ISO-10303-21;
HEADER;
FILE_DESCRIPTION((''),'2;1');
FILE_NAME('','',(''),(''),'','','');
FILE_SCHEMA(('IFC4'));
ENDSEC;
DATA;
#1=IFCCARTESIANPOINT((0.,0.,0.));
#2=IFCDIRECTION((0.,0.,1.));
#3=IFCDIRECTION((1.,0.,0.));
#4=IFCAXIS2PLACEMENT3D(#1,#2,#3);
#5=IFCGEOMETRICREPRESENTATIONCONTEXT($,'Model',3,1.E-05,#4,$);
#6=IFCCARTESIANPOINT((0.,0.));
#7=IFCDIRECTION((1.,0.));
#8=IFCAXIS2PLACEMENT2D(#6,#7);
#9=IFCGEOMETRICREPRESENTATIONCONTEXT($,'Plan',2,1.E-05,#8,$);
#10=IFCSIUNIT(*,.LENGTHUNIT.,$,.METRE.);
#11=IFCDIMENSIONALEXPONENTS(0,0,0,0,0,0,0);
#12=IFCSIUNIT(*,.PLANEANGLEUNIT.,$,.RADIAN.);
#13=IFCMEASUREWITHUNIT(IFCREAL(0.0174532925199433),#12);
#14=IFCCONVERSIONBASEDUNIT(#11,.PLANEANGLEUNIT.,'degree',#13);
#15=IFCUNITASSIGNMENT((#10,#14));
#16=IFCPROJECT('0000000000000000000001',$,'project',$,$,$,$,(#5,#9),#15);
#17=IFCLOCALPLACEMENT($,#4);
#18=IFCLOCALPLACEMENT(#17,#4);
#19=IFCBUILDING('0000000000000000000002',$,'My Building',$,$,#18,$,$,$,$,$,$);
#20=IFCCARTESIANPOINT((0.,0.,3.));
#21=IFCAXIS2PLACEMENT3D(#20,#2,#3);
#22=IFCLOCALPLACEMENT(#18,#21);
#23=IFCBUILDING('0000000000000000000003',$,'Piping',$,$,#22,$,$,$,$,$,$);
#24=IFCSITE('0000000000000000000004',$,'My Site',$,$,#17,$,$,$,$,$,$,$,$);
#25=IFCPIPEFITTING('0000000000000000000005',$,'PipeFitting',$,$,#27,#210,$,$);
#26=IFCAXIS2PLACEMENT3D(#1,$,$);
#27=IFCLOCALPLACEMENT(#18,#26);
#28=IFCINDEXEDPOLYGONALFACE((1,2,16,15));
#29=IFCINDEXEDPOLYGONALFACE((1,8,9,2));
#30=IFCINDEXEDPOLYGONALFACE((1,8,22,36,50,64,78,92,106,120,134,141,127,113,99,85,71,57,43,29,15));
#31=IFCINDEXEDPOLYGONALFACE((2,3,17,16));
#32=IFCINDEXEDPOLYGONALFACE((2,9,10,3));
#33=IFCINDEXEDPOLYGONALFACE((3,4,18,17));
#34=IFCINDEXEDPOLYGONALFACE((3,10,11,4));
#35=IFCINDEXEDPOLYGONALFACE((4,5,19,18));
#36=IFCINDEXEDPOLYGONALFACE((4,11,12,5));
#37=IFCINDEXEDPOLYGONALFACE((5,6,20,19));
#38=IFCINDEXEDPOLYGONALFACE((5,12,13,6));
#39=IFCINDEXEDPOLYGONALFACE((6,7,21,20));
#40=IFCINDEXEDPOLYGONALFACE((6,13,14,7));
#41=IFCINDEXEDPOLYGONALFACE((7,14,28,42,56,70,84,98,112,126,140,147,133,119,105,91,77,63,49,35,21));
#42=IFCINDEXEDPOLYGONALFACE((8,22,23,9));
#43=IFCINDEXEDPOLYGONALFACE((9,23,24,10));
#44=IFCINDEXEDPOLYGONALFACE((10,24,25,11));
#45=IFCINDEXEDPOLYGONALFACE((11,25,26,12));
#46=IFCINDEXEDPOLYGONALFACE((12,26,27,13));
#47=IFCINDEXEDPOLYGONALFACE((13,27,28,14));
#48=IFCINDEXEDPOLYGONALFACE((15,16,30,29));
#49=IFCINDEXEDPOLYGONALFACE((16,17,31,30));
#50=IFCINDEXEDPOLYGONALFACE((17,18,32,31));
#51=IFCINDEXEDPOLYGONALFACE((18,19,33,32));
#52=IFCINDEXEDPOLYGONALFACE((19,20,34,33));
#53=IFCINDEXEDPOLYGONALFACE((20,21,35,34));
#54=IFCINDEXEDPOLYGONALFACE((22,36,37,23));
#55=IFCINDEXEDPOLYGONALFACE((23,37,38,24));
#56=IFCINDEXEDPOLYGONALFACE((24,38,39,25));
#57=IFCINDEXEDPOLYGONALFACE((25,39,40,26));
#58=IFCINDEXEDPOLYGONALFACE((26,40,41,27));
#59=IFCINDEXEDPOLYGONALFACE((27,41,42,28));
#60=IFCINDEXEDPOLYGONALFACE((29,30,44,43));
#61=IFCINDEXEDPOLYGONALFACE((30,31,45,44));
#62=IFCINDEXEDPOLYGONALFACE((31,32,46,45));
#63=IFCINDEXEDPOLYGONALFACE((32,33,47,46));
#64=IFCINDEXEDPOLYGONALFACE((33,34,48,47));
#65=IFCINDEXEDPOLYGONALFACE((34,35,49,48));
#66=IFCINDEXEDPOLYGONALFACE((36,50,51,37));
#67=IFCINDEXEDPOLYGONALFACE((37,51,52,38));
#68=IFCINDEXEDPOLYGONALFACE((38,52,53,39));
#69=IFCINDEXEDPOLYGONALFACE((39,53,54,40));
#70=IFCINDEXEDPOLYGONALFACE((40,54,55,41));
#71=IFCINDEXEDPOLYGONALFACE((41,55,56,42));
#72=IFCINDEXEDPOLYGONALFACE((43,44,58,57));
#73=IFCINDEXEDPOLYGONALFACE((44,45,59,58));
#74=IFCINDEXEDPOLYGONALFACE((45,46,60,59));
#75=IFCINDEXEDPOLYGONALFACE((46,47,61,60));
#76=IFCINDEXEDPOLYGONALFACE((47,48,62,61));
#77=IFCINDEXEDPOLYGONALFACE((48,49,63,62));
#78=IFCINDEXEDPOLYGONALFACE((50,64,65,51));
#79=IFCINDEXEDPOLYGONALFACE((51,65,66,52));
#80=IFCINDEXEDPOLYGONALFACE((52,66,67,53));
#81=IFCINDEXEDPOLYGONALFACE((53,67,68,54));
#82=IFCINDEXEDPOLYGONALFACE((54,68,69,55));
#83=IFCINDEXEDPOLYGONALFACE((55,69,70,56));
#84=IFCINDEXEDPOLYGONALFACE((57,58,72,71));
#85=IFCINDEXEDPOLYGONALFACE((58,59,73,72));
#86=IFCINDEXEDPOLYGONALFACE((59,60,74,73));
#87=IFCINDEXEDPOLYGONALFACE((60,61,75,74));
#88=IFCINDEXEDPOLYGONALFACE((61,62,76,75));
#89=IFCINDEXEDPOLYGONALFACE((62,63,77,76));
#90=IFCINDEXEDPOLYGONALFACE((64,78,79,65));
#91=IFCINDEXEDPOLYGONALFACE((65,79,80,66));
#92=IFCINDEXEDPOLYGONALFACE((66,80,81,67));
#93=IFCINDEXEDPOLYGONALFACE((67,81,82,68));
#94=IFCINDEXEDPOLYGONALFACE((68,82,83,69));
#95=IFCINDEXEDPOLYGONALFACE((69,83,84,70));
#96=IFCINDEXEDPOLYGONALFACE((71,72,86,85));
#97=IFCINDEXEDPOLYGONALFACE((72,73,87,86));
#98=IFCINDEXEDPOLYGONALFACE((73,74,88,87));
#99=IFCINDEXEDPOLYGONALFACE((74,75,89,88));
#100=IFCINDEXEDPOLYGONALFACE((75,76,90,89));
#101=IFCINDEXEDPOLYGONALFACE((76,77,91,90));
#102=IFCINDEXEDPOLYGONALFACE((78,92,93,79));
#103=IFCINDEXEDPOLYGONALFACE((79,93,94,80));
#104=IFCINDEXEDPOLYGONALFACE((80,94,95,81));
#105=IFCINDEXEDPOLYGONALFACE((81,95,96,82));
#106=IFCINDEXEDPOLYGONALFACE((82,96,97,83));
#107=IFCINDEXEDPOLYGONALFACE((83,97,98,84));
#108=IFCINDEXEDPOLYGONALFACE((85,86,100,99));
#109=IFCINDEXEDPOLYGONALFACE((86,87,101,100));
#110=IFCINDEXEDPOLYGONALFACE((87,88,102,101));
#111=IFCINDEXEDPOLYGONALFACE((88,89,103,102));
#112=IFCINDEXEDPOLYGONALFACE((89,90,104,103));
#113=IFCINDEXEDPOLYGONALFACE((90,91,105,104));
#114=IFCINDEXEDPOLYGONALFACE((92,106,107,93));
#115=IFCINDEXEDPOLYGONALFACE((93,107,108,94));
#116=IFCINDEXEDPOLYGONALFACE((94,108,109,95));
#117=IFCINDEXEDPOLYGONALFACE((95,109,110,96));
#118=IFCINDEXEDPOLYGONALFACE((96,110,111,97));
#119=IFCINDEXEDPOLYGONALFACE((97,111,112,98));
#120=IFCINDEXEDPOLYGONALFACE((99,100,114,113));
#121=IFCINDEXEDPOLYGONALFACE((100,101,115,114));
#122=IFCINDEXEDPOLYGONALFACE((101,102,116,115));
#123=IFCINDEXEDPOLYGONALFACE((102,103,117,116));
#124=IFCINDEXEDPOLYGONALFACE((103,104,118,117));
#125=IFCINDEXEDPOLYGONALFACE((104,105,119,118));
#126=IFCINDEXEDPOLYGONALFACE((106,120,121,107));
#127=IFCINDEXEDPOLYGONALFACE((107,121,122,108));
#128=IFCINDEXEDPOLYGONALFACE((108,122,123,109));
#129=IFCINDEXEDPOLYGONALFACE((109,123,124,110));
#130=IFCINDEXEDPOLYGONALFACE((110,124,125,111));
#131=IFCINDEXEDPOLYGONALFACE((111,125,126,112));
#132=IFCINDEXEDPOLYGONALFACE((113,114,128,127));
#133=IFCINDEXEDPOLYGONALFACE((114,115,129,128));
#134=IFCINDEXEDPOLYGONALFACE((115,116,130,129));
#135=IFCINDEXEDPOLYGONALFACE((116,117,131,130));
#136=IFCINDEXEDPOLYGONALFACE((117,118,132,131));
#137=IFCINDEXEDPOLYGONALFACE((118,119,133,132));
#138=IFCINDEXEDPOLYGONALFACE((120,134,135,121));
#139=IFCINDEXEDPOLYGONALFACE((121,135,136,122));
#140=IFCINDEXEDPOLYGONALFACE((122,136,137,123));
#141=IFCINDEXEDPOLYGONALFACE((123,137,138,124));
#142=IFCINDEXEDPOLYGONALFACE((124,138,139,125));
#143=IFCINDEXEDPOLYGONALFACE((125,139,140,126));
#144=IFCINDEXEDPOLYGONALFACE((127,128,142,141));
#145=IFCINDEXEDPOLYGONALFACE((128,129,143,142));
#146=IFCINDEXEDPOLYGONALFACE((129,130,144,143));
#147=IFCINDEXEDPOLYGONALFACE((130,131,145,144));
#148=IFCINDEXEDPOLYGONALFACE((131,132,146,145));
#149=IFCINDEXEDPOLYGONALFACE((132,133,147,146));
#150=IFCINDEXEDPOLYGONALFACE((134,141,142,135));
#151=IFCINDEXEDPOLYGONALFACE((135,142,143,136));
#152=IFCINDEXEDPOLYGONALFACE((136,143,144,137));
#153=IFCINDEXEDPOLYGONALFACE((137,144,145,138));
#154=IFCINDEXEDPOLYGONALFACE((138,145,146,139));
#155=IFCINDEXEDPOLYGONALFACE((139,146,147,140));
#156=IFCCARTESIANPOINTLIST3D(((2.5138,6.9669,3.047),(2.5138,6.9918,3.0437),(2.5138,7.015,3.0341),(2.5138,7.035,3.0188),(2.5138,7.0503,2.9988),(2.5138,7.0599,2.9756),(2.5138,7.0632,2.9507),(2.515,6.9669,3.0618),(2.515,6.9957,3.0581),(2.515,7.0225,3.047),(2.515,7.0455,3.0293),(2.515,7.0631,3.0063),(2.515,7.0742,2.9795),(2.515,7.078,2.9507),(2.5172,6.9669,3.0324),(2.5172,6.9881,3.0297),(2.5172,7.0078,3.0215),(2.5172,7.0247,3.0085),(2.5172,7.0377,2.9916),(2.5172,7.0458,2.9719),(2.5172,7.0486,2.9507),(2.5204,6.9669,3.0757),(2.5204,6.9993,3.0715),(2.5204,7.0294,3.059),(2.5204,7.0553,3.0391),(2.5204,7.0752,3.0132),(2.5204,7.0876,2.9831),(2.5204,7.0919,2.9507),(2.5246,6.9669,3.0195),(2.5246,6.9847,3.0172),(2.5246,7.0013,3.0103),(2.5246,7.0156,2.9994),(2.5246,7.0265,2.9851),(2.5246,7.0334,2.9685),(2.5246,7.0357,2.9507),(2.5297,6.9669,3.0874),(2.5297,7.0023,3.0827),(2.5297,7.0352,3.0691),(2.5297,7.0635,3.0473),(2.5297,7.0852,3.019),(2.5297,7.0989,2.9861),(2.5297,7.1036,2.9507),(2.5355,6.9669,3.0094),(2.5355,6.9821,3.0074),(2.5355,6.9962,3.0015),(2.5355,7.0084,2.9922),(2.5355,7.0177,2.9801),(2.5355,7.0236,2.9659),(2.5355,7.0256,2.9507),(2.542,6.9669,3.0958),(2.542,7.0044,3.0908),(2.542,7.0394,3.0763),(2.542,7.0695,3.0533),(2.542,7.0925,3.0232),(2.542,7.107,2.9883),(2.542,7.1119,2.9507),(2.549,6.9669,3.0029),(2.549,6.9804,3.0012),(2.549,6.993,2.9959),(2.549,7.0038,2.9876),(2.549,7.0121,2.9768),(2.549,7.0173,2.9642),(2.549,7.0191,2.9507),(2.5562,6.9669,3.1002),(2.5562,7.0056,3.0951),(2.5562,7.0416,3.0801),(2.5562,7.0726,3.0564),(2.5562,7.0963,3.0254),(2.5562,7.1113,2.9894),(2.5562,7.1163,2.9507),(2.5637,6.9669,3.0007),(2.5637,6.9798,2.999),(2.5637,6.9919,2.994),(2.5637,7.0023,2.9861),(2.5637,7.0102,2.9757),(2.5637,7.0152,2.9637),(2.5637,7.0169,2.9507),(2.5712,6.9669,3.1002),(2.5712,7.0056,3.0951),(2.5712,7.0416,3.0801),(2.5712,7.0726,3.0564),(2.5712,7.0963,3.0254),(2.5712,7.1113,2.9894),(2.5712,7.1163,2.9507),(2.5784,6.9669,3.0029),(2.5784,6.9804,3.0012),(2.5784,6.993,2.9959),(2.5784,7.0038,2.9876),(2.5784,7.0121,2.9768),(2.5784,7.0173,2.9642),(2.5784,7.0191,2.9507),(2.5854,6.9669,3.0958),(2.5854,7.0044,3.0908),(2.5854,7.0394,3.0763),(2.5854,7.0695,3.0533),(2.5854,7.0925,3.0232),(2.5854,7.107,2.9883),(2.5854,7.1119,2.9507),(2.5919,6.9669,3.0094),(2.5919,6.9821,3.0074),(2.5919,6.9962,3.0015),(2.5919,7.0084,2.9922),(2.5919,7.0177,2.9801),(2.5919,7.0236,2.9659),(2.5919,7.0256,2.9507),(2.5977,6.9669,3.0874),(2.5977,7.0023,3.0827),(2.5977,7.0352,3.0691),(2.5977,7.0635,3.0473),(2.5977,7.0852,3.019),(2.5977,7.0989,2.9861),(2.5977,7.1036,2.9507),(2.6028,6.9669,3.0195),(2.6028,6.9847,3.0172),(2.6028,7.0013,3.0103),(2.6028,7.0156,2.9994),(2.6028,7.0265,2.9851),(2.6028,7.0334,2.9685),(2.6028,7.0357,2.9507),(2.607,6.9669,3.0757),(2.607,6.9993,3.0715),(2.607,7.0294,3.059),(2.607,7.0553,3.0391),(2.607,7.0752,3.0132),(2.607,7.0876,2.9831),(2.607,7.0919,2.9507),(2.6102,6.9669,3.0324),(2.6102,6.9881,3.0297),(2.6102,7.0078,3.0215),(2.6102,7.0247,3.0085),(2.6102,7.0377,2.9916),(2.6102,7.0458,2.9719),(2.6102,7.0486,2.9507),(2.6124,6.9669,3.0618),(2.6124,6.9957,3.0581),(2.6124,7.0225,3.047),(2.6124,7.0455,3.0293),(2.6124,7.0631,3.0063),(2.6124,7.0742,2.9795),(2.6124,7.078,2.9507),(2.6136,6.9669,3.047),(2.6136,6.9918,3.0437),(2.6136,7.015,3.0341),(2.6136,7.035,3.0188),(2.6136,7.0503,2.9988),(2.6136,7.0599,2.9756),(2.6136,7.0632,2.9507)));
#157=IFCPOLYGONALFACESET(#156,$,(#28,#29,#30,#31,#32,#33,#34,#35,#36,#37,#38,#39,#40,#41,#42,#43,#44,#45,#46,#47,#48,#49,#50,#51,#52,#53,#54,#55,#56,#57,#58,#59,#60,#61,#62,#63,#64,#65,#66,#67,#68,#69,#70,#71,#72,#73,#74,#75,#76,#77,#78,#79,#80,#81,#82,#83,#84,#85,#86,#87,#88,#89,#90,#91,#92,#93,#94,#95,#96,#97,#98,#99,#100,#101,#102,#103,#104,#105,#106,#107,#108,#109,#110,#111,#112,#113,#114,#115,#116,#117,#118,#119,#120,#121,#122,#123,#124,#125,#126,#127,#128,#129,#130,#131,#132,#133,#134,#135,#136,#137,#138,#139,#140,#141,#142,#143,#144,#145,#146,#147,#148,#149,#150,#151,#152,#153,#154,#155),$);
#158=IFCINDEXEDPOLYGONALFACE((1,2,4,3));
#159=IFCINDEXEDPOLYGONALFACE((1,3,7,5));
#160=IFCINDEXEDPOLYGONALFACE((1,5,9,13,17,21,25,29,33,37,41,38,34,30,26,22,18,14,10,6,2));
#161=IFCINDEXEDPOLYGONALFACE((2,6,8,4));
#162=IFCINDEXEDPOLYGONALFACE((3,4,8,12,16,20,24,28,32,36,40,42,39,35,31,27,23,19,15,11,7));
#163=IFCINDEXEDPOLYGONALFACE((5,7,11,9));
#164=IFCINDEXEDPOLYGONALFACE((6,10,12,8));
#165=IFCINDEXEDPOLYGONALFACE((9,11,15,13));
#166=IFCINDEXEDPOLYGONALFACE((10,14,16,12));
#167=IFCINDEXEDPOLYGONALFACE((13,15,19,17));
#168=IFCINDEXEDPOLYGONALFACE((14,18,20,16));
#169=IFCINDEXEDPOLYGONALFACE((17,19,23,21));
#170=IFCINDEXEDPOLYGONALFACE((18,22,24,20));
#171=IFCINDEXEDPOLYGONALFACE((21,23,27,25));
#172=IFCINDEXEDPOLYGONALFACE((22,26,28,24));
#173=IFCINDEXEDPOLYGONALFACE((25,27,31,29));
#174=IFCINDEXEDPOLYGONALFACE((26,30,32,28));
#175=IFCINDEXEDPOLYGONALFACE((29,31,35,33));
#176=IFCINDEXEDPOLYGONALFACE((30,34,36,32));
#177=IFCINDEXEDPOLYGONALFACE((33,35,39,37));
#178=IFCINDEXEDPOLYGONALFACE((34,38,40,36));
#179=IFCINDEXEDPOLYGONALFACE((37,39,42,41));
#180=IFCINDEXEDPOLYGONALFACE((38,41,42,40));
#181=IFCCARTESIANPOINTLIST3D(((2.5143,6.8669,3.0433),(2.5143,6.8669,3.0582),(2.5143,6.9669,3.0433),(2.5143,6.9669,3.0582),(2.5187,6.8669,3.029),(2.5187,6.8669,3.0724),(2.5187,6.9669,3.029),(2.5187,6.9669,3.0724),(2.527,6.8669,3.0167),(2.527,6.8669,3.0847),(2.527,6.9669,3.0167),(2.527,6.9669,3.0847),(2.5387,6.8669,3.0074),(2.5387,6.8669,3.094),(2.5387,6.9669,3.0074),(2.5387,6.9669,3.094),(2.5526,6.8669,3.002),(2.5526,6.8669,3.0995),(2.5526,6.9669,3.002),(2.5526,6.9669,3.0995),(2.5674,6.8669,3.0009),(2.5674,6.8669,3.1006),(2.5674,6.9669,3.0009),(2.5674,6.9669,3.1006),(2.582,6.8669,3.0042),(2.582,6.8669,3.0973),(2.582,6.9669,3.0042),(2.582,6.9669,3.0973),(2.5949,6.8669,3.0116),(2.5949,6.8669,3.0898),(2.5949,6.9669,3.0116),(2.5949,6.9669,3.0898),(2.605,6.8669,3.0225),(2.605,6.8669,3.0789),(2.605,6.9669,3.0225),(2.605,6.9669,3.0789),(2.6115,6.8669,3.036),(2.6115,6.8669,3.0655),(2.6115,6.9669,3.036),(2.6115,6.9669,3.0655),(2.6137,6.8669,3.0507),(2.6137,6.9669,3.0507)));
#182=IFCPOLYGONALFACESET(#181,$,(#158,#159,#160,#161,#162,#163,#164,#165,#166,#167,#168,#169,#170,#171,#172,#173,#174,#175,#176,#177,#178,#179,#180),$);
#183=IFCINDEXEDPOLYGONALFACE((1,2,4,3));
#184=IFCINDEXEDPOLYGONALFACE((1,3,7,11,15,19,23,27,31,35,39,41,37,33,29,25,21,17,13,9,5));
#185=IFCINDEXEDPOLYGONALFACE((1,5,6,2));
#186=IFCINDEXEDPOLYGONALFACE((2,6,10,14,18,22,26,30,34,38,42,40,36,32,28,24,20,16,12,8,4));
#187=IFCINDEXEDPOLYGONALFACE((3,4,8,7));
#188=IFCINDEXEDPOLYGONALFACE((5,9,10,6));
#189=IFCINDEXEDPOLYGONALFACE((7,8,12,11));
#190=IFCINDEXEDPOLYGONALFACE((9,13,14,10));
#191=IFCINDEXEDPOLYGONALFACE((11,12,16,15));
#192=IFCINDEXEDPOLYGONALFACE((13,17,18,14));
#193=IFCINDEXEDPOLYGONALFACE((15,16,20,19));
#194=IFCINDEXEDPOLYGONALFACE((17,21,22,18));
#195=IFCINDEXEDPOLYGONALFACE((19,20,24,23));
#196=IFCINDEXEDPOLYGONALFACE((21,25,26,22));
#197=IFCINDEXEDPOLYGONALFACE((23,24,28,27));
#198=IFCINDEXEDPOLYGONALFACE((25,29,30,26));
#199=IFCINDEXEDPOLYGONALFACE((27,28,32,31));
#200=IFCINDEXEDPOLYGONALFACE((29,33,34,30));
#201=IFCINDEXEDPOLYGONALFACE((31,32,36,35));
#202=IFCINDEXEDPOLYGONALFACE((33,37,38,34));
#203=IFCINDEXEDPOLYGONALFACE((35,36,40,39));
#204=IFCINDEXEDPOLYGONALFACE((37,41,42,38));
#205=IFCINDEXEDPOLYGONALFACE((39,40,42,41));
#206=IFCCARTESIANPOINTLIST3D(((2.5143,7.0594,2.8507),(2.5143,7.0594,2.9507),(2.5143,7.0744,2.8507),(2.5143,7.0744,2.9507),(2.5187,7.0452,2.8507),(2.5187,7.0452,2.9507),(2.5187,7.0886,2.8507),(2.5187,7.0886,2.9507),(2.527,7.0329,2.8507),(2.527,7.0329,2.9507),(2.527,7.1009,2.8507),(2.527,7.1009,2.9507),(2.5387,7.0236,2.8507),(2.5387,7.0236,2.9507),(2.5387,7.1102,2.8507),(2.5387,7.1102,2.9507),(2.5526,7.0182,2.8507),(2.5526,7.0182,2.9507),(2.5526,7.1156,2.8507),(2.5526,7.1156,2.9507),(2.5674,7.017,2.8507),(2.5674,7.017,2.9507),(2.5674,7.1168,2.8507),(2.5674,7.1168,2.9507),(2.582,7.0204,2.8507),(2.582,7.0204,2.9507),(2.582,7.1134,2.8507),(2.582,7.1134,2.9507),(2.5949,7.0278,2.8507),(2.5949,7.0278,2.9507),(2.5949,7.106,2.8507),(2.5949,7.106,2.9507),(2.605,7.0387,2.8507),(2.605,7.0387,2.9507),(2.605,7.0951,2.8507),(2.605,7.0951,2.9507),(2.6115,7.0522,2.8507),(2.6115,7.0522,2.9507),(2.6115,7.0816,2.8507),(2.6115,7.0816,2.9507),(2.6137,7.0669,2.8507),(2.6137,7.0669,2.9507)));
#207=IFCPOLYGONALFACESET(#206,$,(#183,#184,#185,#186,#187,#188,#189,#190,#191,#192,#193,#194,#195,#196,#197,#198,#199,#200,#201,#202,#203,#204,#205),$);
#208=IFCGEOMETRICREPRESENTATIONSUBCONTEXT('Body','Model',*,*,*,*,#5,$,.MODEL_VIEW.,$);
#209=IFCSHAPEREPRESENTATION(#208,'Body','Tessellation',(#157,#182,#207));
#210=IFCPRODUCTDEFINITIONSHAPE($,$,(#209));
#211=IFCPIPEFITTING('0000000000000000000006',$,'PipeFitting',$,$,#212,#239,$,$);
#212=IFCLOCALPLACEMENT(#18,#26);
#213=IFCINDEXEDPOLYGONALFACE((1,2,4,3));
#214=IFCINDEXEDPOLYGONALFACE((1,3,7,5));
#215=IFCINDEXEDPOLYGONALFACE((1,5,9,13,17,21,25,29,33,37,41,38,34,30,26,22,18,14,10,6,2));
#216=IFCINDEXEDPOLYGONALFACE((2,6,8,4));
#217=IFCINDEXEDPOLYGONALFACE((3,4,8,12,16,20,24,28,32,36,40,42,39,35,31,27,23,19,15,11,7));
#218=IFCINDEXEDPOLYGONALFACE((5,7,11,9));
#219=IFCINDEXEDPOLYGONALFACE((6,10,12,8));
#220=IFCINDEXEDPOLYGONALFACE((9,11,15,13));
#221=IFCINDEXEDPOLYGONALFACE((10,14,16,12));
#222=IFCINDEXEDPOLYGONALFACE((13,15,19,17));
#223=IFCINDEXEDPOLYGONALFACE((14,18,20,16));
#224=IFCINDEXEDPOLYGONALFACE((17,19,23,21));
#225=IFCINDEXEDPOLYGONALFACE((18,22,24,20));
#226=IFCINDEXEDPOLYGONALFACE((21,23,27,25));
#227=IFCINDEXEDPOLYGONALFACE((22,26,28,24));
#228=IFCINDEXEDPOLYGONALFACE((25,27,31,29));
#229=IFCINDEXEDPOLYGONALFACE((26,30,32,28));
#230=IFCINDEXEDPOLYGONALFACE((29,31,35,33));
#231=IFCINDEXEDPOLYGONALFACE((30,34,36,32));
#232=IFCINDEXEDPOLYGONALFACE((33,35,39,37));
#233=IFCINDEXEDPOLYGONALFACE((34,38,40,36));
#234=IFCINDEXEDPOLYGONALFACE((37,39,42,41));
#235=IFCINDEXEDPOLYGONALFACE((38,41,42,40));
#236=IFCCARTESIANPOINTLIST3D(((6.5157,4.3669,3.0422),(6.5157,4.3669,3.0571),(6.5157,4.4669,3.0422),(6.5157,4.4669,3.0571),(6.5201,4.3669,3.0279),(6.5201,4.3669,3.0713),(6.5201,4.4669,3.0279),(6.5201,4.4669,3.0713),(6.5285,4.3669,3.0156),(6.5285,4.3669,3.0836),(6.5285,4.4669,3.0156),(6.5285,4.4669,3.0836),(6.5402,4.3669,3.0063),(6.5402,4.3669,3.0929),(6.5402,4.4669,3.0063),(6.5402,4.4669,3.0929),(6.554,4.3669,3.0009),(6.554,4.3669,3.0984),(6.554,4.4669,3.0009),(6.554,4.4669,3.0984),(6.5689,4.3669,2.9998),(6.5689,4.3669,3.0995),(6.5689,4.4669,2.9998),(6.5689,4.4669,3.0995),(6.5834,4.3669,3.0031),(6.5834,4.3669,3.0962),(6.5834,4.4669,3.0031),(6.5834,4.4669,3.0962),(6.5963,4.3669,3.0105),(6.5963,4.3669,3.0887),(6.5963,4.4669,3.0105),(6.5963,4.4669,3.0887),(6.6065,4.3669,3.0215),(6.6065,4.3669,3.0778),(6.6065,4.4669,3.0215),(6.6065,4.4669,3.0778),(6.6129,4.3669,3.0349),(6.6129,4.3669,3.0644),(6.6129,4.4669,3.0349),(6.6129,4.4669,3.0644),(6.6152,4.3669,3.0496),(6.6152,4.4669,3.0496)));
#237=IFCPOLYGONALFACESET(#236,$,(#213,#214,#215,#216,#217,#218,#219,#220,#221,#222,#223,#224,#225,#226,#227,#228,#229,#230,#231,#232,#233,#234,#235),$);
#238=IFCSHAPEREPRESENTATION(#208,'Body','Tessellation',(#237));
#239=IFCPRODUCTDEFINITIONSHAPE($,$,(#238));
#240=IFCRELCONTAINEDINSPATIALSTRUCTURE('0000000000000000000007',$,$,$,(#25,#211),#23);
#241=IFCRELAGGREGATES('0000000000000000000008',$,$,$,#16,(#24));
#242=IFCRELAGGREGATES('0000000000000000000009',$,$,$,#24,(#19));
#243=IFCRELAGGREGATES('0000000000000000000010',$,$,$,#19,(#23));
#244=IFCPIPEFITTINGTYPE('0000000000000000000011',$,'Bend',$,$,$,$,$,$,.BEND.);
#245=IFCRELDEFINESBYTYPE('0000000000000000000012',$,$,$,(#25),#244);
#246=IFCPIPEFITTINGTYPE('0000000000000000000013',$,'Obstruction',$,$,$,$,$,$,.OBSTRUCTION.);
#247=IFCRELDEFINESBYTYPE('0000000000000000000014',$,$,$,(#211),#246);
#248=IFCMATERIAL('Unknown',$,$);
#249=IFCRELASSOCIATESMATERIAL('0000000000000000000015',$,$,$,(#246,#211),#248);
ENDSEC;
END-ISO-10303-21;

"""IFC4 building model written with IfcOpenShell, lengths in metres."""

from ifc_helpers import new_model, entity, si_unit, converted_unit, frame, origin_with_axes, origin_2d_with_axis, place, context, subcontext, project, spatial, circle, extrude, source, transform, mapped, material, material_profile, profile_set, profile_usage, type_object, type_shapes, element, save


model = new_model("IFC4")

# Units and contexts
model_context = context("Model", 3, precision=1e-05, world=origin_with_axes())
plan_context = context("Plan", 2, precision=1e-05, world=origin_2d_with_axis())
body_context = subcontext(model_context, "Body", "Model", "MODEL_VIEW")
ifc_project = project(units=[si_unit("LENGTHUNIT", "METRE"), converted_unit("PLANEANGLEUNIT", "degree", entity("IfcReal", 0.0174532925199433), si_unit("PLANEANGLEUNIT", "RADIAN"), dimensions=[0, 0, 0, 0, 0, 0, 0])], contexts=[model_context, plan_context])

# Site, buildings
site_placement = place(None, origin_with_axes())
site = spatial("IfcSite", under=ifc_project, at=site_placement, Name="My Site")
building_1_placement = place(site_placement, origin_with_axes())
building_1 = spatial("IfcBuilding", under=site, at=building_1_placement, Name="My Building")
building_2_placement = place(building_1_placement, frame((0.0, 0.0, 3.0), z_axis=(0.0, 0.0, 1.0), x_axis=(1.0, 0.0, 0.0)))
building_2 = spatial("IfcBuilding", under=building_1, at=building_2_placement, Name="Piping")

# Shared definitions
ifc_material = material(Name="Unknown")

# Pipe fittings
pipe_fitting_type_1 = type_object("IfcPipeFittingType", Name="Bend", PredefinedType="BEND")
shared_shape = source(origin_with_axes(), body_context, "Body", "SolidModel", [
    entity("IfcSweptDiskSolid", entity("IfcIndexedPolyCurve", entity("IfcCartesianPointList3D", [[0.0, 0.0, 0.1], [0.0, 0.0293, 0.1707], [0.0, 0.1, 0.2]]), [entity("IfcArcIndex", [1, 2, 3])]), 0.05),
    extrude(circle(Radius=0.05), origin_with_axes(), (0.0, 0.0, 1.0), 0.1),
    extrude(circle(Radius=0.05), frame((0.0, 0.1, 0.2), z_axis=(0.0, 1.0, 0.0), x_axis=(1.0, 0.0, 0.0)), (0.0, 0.0, 1.0), 0.1),
])
type_shapes(pipe_fitting_type_1, [shared_shape])
for number, where, z_axis, x_axis, name in (
    (1, (2.5637, 6.8669, 0.0507), (0.0, 1.0, 0.0), (1.0, 0.0, 0.0), "PipeFitting"),
):
    element("IfcPipeFitting", number, at=place(building_2_placement, frame(where, z_axis=z_axis, x_axis=x_axis)), inside=building_2, type_object=pipe_fitting_type_1, Name=name, context=body_context, shape_type="MappedRepresentation", body=[
        mapped(shared_shape, transform((0.0, 0.0, 0.0), x_axis=(1.0, 0.0, 0.0), y_axis=(0.0, 1.0, 0.0), z_axis=(0.0, 0.0, 1.0), scale=1.0)),
    ])
ifc_material_profile_1 = material_profile(ifc_material, circle(Radius=0.05))
ifc_profile_set_1 = profile_set([ifc_material_profile_1])
ifc_profile_usage_1 = profile_usage(ifc_profile_set_1, cardinal=5)
pipe_fitting_type_2 = type_object("IfcPipeFittingType", Name="Obstruction", PredefinedType="OBSTRUCTION", material=ifc_profile_set_1)
pipe_fitting_1_placement = place(building_2_placement, frame((6.5652, 4.3669, 0.0496), z_axis=(0.0, 1.0, 0.000001), x_axis=(1.0, 0.0, 0.0)))
element("IfcPipeFitting", 2, at=pipe_fitting_1_placement, inside=building_2, type_object=pipe_fitting_type_2, material=ifc_profile_usage_1, Name="PipeFitting", context=body_context, shape_type="SweptSolid", body=[
    extrude(circle(Radius=0.05), origin_with_axes(), (0.0, 0.0, 1.0), 0.1),
])

save(model, "model.ifc")
